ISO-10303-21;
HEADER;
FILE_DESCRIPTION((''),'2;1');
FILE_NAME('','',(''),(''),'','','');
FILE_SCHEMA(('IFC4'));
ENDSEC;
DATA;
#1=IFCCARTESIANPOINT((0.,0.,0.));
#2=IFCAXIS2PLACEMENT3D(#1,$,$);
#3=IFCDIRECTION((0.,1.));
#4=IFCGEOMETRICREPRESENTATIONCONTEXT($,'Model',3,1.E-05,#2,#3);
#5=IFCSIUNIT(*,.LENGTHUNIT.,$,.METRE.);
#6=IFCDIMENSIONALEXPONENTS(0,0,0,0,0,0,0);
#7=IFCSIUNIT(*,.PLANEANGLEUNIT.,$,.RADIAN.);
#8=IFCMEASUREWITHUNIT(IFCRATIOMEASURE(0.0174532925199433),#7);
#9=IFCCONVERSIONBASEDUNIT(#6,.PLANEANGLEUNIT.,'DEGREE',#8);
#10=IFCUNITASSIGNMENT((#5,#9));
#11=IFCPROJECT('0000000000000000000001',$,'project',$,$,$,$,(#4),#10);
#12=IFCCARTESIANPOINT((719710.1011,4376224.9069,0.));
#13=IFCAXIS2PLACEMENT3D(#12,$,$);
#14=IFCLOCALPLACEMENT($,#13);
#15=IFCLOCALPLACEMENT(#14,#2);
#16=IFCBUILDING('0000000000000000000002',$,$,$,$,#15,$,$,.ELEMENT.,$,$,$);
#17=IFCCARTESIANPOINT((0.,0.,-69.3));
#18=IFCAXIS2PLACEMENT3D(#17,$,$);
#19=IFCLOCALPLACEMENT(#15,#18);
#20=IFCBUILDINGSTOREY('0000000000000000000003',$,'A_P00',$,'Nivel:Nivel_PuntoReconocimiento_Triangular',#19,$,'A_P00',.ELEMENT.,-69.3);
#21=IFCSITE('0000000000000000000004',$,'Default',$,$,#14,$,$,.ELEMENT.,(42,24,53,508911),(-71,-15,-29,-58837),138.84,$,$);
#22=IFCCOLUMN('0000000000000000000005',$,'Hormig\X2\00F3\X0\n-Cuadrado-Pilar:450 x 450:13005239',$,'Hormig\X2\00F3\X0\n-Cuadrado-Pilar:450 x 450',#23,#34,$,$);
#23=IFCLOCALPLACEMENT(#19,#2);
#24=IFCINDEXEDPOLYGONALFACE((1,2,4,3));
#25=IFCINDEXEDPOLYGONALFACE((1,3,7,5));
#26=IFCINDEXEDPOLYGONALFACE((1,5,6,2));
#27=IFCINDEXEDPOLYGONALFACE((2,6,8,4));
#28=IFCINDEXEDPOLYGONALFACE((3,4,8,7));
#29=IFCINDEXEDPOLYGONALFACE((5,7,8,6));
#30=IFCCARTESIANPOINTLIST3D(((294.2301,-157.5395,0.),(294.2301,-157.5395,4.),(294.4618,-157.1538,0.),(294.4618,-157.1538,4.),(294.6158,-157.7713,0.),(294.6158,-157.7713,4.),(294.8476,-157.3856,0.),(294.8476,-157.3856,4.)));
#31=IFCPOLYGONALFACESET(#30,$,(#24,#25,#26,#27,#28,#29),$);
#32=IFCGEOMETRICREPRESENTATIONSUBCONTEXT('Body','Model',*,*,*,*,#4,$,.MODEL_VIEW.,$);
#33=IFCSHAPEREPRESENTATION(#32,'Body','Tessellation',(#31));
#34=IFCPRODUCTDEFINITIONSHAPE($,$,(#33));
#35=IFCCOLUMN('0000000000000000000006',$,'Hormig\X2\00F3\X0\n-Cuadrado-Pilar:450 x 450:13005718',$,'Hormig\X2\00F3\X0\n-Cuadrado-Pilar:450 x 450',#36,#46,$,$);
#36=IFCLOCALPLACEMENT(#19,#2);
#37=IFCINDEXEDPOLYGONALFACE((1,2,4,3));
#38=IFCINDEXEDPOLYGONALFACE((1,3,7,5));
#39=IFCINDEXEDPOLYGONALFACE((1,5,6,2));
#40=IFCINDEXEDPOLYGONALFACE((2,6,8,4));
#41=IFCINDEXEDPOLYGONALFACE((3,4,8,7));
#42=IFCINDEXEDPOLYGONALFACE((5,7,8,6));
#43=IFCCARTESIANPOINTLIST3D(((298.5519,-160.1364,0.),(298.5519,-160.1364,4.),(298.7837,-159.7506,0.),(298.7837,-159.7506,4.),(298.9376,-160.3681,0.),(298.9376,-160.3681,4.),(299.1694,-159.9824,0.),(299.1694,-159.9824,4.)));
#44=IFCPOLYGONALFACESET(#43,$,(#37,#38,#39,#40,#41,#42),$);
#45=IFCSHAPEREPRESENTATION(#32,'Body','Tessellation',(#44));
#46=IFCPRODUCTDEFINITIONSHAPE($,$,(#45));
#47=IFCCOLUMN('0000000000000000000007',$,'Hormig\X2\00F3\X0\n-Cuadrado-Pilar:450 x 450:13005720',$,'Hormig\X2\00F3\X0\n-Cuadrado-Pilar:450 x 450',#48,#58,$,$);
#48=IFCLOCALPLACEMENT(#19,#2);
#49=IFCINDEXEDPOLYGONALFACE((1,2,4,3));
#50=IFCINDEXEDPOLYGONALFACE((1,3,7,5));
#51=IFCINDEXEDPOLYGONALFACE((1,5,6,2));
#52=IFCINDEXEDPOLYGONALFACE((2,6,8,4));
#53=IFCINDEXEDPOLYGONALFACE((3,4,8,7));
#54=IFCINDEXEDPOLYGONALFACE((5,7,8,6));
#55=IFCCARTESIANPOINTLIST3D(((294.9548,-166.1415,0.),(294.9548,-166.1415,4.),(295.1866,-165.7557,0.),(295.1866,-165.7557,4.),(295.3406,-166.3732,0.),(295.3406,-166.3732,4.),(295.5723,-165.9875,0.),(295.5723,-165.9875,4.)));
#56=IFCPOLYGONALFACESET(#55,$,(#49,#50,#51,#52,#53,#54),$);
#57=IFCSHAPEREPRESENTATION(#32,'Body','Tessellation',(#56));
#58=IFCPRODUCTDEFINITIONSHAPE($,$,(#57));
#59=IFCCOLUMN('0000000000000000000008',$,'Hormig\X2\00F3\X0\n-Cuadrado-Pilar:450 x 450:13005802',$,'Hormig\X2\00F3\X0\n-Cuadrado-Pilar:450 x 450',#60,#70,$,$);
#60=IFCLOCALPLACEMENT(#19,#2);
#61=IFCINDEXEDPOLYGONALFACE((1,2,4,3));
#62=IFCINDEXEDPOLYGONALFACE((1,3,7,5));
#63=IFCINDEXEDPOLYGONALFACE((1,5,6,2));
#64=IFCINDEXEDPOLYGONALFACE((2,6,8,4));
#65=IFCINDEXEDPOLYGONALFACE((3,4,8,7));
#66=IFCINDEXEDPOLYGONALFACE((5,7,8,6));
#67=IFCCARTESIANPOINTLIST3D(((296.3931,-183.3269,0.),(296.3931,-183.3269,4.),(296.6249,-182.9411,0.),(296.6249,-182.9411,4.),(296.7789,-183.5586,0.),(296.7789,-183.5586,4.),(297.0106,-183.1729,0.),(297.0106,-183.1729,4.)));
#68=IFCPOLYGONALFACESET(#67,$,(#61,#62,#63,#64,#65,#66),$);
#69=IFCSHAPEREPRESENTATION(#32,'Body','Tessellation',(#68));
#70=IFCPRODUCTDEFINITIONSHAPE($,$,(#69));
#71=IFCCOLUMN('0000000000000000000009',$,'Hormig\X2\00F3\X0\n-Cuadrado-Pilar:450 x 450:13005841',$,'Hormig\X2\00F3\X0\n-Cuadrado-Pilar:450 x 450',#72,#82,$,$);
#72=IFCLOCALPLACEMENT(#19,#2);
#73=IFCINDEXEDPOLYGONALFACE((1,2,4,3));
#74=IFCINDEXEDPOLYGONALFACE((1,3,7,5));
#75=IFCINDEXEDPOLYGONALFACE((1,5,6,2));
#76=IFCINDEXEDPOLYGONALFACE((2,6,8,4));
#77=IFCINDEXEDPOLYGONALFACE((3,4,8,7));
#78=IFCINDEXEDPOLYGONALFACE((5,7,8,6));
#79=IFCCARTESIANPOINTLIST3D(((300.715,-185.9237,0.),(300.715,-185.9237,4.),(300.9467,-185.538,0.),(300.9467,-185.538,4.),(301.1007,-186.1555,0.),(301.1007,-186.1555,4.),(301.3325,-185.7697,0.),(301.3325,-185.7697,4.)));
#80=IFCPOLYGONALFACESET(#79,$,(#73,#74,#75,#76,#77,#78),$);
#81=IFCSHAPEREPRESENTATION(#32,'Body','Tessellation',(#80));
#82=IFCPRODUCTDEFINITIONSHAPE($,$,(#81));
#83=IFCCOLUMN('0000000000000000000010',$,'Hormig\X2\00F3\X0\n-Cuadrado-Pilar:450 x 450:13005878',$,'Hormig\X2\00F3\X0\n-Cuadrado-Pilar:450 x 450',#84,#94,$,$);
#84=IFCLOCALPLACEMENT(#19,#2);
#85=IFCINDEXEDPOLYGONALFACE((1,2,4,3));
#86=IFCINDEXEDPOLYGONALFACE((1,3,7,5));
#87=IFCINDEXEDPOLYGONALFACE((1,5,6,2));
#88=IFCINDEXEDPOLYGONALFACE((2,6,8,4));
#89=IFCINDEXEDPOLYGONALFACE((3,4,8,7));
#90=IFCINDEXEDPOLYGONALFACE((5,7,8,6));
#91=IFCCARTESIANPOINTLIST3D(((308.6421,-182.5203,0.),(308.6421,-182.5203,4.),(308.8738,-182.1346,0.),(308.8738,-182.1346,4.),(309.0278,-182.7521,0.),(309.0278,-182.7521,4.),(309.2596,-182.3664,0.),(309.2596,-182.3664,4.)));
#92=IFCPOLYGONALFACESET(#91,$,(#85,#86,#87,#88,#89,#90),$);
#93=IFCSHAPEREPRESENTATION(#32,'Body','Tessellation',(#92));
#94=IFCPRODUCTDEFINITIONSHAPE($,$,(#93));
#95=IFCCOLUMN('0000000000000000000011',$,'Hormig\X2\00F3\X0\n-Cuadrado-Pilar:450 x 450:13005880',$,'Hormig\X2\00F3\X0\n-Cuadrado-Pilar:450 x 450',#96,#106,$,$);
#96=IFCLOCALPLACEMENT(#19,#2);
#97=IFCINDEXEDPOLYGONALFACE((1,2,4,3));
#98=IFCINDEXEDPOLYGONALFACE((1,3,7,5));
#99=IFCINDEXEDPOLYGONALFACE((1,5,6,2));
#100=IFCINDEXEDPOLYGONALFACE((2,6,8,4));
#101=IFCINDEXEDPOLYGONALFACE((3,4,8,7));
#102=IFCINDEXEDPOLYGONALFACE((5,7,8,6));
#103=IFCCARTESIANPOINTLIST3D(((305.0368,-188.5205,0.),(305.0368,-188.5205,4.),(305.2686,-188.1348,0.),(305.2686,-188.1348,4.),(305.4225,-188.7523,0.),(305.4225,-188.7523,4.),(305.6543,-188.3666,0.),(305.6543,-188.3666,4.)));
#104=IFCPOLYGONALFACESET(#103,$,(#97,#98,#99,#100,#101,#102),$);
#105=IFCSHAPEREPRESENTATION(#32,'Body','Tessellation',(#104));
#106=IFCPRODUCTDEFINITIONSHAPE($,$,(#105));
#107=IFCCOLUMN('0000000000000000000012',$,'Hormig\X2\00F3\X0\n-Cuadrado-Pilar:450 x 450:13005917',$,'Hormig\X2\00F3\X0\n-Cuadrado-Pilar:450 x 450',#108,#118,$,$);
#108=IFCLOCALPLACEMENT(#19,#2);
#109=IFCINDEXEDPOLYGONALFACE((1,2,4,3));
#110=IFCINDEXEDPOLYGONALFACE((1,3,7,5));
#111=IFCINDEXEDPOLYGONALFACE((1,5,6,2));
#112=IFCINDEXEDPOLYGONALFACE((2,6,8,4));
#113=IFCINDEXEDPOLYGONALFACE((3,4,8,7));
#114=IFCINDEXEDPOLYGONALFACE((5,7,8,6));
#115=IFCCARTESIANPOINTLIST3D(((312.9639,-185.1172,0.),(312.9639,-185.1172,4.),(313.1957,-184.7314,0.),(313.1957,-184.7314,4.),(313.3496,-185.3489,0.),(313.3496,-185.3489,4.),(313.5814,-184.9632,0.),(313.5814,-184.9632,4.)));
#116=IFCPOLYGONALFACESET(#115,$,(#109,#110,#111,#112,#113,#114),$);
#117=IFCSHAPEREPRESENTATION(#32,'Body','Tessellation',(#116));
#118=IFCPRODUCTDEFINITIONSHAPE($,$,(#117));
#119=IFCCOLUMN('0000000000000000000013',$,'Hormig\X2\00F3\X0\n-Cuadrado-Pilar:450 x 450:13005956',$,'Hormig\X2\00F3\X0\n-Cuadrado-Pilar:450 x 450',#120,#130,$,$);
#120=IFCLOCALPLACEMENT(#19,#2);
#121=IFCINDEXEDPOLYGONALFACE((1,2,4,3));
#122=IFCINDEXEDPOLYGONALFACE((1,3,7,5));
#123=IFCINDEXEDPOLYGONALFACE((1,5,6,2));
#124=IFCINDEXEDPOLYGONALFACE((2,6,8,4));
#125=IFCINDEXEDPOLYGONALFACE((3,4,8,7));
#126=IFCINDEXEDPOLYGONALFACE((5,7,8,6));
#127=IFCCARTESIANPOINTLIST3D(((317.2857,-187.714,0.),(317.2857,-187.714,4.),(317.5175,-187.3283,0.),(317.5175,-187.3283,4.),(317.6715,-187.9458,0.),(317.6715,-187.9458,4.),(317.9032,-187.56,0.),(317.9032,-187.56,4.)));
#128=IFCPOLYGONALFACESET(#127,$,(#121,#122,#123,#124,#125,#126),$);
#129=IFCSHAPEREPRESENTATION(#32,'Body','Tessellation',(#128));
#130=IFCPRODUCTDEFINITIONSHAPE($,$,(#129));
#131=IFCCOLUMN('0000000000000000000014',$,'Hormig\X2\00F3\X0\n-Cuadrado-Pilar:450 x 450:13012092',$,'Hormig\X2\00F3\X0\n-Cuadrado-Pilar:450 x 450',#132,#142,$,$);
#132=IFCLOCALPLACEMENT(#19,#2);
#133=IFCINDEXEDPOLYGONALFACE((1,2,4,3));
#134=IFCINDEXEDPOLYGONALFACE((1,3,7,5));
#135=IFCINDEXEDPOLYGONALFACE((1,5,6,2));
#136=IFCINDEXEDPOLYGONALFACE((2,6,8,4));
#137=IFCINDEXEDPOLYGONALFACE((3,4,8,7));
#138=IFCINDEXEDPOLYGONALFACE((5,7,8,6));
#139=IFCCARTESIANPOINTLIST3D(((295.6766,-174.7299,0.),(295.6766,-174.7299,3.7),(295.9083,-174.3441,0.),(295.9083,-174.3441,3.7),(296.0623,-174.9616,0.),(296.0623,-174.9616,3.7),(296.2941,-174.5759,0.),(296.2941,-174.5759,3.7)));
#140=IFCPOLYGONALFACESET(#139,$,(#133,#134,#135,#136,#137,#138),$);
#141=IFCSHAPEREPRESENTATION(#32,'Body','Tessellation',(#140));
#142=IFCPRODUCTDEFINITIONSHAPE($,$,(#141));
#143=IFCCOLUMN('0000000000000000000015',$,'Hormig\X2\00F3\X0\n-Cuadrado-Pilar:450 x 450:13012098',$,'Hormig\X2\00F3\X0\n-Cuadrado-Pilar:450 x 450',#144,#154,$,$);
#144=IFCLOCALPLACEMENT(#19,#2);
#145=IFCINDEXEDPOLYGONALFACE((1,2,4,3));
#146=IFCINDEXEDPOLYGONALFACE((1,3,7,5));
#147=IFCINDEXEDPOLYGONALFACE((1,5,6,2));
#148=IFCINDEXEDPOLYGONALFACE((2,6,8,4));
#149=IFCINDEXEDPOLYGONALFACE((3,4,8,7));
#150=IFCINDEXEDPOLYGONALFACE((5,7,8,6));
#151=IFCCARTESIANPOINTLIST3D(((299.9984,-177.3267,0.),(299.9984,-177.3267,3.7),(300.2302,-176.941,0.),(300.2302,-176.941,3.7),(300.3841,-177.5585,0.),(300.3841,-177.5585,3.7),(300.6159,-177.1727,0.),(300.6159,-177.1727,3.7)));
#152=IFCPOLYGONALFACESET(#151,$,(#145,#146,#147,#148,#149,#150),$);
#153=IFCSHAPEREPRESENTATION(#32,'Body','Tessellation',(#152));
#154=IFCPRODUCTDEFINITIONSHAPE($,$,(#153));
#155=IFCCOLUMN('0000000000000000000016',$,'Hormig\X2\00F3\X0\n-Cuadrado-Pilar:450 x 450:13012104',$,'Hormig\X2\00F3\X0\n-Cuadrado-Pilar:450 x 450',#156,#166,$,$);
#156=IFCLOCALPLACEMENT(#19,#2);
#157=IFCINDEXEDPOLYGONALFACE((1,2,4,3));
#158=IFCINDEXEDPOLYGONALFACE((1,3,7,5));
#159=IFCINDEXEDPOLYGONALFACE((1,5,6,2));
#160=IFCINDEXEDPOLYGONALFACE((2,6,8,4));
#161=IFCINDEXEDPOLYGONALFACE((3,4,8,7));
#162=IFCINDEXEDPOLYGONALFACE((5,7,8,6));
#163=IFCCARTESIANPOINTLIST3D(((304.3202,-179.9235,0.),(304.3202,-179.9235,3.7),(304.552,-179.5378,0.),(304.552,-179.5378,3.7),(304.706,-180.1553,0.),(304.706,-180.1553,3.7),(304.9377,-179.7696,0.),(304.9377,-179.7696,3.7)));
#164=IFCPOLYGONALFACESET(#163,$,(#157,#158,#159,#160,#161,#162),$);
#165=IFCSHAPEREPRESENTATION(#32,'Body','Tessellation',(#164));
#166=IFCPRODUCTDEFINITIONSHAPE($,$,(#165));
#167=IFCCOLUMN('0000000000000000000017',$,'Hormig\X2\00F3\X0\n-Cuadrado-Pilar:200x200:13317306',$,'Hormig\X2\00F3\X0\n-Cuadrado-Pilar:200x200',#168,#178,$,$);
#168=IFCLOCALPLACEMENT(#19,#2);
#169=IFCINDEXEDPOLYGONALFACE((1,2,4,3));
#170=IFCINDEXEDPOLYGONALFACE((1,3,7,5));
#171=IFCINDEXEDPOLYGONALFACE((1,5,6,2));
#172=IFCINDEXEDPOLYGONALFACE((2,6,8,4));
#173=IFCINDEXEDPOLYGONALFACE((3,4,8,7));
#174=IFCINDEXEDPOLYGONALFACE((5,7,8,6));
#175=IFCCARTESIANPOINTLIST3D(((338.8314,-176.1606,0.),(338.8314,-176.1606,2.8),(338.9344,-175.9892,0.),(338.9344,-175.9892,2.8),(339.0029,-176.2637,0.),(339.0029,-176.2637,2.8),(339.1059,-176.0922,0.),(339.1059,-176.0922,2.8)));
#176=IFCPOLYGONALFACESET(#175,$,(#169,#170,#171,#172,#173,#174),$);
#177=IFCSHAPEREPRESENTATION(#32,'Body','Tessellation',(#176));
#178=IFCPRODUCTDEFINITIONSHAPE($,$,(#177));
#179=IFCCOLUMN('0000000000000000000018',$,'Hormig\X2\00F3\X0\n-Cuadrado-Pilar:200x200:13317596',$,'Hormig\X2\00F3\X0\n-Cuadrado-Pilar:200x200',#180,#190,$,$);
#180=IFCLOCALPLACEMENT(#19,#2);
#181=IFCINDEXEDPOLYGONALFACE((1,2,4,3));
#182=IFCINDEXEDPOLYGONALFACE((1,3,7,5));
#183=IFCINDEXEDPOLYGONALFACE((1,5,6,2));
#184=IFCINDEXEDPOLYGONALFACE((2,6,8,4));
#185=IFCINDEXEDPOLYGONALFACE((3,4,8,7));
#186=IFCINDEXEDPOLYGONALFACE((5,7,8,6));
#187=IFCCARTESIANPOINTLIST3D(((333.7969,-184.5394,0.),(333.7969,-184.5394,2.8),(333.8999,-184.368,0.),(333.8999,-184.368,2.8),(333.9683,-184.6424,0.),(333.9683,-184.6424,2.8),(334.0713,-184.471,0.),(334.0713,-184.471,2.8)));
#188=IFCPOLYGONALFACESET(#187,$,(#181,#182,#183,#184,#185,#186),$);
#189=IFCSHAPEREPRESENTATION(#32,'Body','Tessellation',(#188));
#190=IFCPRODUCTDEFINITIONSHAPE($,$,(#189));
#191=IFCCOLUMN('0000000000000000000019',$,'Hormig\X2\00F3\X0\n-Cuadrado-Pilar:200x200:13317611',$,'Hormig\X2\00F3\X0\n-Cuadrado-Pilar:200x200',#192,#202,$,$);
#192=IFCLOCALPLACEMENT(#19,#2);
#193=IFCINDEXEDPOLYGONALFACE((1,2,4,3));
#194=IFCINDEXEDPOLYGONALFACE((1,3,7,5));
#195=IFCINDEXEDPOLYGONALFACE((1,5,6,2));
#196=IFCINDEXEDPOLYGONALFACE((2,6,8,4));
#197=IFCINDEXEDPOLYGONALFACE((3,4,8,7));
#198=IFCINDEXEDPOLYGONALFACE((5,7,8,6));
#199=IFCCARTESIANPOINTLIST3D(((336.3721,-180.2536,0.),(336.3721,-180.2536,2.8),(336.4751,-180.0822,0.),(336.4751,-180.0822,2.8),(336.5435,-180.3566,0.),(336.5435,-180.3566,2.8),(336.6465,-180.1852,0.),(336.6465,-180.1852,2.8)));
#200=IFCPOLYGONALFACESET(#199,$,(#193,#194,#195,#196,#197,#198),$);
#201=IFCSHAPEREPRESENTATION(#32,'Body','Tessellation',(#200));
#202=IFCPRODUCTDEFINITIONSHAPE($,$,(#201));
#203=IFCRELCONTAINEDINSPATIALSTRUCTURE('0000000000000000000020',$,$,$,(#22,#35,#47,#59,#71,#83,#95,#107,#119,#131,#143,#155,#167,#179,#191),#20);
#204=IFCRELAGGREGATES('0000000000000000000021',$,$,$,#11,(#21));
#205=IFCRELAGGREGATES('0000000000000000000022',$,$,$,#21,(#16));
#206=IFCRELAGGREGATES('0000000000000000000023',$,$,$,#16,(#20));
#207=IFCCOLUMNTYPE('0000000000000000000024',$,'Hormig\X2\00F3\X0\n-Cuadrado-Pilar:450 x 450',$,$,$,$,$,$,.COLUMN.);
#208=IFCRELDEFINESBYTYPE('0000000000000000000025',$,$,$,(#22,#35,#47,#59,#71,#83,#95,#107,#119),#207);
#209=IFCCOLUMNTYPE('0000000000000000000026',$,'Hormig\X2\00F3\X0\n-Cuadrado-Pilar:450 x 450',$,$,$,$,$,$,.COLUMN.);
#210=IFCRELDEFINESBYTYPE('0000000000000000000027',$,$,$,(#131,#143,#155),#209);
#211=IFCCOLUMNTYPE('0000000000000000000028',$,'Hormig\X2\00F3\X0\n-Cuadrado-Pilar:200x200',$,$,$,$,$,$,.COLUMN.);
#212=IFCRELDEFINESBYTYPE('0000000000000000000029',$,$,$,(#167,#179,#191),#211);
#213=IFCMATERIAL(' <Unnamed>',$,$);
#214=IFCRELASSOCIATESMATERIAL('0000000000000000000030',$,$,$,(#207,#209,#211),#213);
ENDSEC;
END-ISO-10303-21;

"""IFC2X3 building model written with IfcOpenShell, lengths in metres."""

from ifc_helpers import new_model, entity, si_unit, converted_unit, direction, frame, origin, origin_2d_with_axis, place, context, subcontext, project, spatial, rectangle, extrude, source, transform, mapped, material, type_object, type_shapes, element, save


model = new_model("IFC2X3")

# Units and contexts
model_context = context("Model", 3, precision=1e-05, world=origin(), true_north=direction((0.0, 1.0)))
body_context = subcontext(model_context, "Body", "Model", "MODEL_VIEW")
ifc_project = project(units=[si_unit("LENGTHUNIT", "METRE"), converted_unit("PLANEANGLEUNIT", "DEGREE", entity("IfcRatioMeasure", 0.0174532925199433), si_unit("PLANEANGLEUNIT", "RADIAN"), dimensions=[0, 0, 0, 0, 0, 0, 0])], contexts=[model_context])

# Site, building, storey
site_placement = place(None, frame((719710.1011, 4376224.9069, 0.0)))
site = spatial("IfcSite", under=ifc_project, at=site_placement, Name="Default", CompositionType="ELEMENT", RefLatitude=(42, 24, 53, 508911), RefLongitude=(-71, -15, -29, -58837), RefElevation=138.84)
building_placement = place(site_placement, origin())
building = spatial("IfcBuilding", under=site, at=building_placement, CompositionType="ELEMENT")
storey_placement = place(building_placement, frame((0.0, 0.0, -69.3)))
storey = spatial("IfcBuildingStorey", under=building, at=storey_placement, Name="A_P00", ObjectType="Nivel:Nivel_PuntoReconocimiento_Triangular", LongName="A_P00", CompositionType="ELEMENT", Elevation=-69.3)

# Columns
ifc_material = material(Name=" <Unnamed>")
column_type_1 = type_object("IfcColumnType", Name="Hormigón-Cuadrado-Pilar:450 x 450", PredefinedType="COLUMN", material=ifc_material)
shared_shape_1 = source(origin(), body_context, "Body", "SweptSolid", [
    extrude(rectangle(XDim=0.45, YDim=0.45, at=origin_2d_with_axis()), frame((0.0, 0.0, -69.3), z_axis=(0.0, 0.0, 1.0), x_axis=(0.0, -1.0, 0.0)), (0.0, 0.0, 1.0), 4.0),
])
type_shapes(column_type_1, [shared_shape_1])
for number, where, z_axis, x_axis, name in (
    (1, (294.5388, -157.4626, 69.3), (0.0, 0.0, 1.0), (0.857167, -0.515038, 0.0), "Hormigón-Cuadrado-Pilar:450 x 450:13005239"),
    (2, (298.8607, -160.0594, 69.3), (0.0, 0.0, 1.0), (0.857167, -0.515038, 0.0), "Hormigón-Cuadrado-Pilar:450 x 450:13005718"),
    (3, (295.2636, -166.0645, 69.3), (0.0, 0.0, 1.0), (0.857167, -0.515038, 0.0), "Hormigón-Cuadrado-Pilar:450 x 450:13005720"),
    (4, (296.7019, -183.2499, 69.3), (0.0, 0.0, 1.0), (0.857167, -0.515038, 0.0), "Hormigón-Cuadrado-Pilar:450 x 450:13005802"),
    (5, (301.0237, -185.8467, 69.3), (0.0, 0.0, 1.0), (0.857167, -0.515038, 0.0), "Hormigón-Cuadrado-Pilar:450 x 450:13005841"),
    (6, (308.9508, -182.4434, 69.3), (0.0, 0.0, 1.0), (0.857167, -0.515038, 0.0), "Hormigón-Cuadrado-Pilar:450 x 450:13005878"),
    (7, (305.3456, -188.4435, 69.3), (0.0, 0.0, 1.0), (0.857167, -0.515038, 0.0), "Hormigón-Cuadrado-Pilar:450 x 450:13005880"),
    (8, (313.2727, -185.0402, 69.3), (0.0, 0.0, 1.0), (0.857167, -0.515038, 0.0), "Hormigón-Cuadrado-Pilar:450 x 450:13005917"),
    (9, (317.5945, -187.637, 69.3), (0.0, 0.0, 1.0), (0.857167, -0.515038, 0.0), "Hormigón-Cuadrado-Pilar:450 x 450:13005956"),
):
    element("IfcColumn", number, at=place(storey_placement, frame(where, z_axis=z_axis, x_axis=x_axis)), inside=storey, type_object=column_type_1, Name=name, ObjectType="Hormigón-Cuadrado-Pilar:450 x 450", context=body_context, shape_type="MappedRepresentation", body=[
        mapped(shared_shape_1, transform((0.0, 0.0, 0.0), scale=1.0)),
    ])
column_type_2 = type_object("IfcColumnType", Name="Hormigón-Cuadrado-Pilar:450 x 450", PredefinedType="COLUMN", material=ifc_material)
shared_shape_2 = source(origin(), body_context, "Body", "SweptSolid", [
    extrude(rectangle(XDim=0.45, YDim=0.45, at=origin_2d_with_axis()), frame((0.0, 0.0, -69.3), z_axis=(0.0, 0.0, 1.0), x_axis=(0.0, -1.0, 0.0)), (0.0, 0.0, 1.0), 3.7),
])
type_shapes(column_type_2, [shared_shape_2])
for number, where, z_axis, x_axis, name in (
    (10, (295.9853, -174.6529, 69.3), (0.0, 0.0, 1.0), (0.857167, -0.515038, 0.0), "Hormigón-Cuadrado-Pilar:450 x 450:13012092"),
    (11, (300.3071, -177.2497, 69.3), (0.0, 0.0, 1.0), (0.857167, -0.515038, 0.0), "Hormigón-Cuadrado-Pilar:450 x 450:13012098"),
    (12, (304.629, -179.8465, 69.3), (0.0, 0.0, 1.0), (0.857167, -0.515038, 0.0), "Hormigón-Cuadrado-Pilar:450 x 450:13012104"),
):
    element("IfcColumn", number, at=place(storey_placement, frame(where, z_axis=z_axis, x_axis=x_axis)), inside=storey, type_object=column_type_2, Name=name, ObjectType="Hormigón-Cuadrado-Pilar:450 x 450", context=body_context, shape_type="MappedRepresentation", body=[
        mapped(shared_shape_2, transform((0.0, 0.0, 0.0), scale=1.0)),
    ])
column_type_3 = type_object("IfcColumnType", Name="Hormigón-Cuadrado-Pilar:200x200", PredefinedType="COLUMN", material=ifc_material)
shared_shape_3 = source(origin(), body_context, "Body", "SweptSolid", [
    extrude(rectangle(XDim=0.2, YDim=0.2, at=origin_2d_with_axis()), frame((0.0, 0.0, -69.3), z_axis=(0.0, 0.0, 1.0), x_axis=(0.0, -1.0, 0.0)), (0.0, 0.0, 1.0), 2.8),
])
type_shapes(column_type_3, [shared_shape_3])
for number, where, z_axis, x_axis, name in (
    (13, (338.9687, -176.1264, 69.3), (0.0, 0.0, 1.0), (0.857167, -0.515038, 0.0), "Hormigón-Cuadrado-Pilar:200x200:13317306"),
    (14, (333.9341, -184.5052, 69.3), (0.0, 0.0, 1.0), (0.857167, -0.515038, 0.0), "Hormigón-Cuadrado-Pilar:200x200:13317596"),
    (15, (336.5093, -180.2194, 69.3), (0.0, 0.0, 1.0), (0.857167, -0.515038, 0.0), "Hormigón-Cuadrado-Pilar:200x200:13317611"),
):
    element("IfcColumn", number, at=place(storey_placement, frame(where, z_axis=z_axis, x_axis=x_axis)), inside=storey, type_object=column_type_3, Name=name, ObjectType="Hormigón-Cuadrado-Pilar:200x200", context=body_context, shape_type="MappedRepresentation", body=[
        mapped(shared_shape_3, transform((0.0, 0.0, 0.0), scale=1.0)),
    ])

save(model, "model.ifc")
